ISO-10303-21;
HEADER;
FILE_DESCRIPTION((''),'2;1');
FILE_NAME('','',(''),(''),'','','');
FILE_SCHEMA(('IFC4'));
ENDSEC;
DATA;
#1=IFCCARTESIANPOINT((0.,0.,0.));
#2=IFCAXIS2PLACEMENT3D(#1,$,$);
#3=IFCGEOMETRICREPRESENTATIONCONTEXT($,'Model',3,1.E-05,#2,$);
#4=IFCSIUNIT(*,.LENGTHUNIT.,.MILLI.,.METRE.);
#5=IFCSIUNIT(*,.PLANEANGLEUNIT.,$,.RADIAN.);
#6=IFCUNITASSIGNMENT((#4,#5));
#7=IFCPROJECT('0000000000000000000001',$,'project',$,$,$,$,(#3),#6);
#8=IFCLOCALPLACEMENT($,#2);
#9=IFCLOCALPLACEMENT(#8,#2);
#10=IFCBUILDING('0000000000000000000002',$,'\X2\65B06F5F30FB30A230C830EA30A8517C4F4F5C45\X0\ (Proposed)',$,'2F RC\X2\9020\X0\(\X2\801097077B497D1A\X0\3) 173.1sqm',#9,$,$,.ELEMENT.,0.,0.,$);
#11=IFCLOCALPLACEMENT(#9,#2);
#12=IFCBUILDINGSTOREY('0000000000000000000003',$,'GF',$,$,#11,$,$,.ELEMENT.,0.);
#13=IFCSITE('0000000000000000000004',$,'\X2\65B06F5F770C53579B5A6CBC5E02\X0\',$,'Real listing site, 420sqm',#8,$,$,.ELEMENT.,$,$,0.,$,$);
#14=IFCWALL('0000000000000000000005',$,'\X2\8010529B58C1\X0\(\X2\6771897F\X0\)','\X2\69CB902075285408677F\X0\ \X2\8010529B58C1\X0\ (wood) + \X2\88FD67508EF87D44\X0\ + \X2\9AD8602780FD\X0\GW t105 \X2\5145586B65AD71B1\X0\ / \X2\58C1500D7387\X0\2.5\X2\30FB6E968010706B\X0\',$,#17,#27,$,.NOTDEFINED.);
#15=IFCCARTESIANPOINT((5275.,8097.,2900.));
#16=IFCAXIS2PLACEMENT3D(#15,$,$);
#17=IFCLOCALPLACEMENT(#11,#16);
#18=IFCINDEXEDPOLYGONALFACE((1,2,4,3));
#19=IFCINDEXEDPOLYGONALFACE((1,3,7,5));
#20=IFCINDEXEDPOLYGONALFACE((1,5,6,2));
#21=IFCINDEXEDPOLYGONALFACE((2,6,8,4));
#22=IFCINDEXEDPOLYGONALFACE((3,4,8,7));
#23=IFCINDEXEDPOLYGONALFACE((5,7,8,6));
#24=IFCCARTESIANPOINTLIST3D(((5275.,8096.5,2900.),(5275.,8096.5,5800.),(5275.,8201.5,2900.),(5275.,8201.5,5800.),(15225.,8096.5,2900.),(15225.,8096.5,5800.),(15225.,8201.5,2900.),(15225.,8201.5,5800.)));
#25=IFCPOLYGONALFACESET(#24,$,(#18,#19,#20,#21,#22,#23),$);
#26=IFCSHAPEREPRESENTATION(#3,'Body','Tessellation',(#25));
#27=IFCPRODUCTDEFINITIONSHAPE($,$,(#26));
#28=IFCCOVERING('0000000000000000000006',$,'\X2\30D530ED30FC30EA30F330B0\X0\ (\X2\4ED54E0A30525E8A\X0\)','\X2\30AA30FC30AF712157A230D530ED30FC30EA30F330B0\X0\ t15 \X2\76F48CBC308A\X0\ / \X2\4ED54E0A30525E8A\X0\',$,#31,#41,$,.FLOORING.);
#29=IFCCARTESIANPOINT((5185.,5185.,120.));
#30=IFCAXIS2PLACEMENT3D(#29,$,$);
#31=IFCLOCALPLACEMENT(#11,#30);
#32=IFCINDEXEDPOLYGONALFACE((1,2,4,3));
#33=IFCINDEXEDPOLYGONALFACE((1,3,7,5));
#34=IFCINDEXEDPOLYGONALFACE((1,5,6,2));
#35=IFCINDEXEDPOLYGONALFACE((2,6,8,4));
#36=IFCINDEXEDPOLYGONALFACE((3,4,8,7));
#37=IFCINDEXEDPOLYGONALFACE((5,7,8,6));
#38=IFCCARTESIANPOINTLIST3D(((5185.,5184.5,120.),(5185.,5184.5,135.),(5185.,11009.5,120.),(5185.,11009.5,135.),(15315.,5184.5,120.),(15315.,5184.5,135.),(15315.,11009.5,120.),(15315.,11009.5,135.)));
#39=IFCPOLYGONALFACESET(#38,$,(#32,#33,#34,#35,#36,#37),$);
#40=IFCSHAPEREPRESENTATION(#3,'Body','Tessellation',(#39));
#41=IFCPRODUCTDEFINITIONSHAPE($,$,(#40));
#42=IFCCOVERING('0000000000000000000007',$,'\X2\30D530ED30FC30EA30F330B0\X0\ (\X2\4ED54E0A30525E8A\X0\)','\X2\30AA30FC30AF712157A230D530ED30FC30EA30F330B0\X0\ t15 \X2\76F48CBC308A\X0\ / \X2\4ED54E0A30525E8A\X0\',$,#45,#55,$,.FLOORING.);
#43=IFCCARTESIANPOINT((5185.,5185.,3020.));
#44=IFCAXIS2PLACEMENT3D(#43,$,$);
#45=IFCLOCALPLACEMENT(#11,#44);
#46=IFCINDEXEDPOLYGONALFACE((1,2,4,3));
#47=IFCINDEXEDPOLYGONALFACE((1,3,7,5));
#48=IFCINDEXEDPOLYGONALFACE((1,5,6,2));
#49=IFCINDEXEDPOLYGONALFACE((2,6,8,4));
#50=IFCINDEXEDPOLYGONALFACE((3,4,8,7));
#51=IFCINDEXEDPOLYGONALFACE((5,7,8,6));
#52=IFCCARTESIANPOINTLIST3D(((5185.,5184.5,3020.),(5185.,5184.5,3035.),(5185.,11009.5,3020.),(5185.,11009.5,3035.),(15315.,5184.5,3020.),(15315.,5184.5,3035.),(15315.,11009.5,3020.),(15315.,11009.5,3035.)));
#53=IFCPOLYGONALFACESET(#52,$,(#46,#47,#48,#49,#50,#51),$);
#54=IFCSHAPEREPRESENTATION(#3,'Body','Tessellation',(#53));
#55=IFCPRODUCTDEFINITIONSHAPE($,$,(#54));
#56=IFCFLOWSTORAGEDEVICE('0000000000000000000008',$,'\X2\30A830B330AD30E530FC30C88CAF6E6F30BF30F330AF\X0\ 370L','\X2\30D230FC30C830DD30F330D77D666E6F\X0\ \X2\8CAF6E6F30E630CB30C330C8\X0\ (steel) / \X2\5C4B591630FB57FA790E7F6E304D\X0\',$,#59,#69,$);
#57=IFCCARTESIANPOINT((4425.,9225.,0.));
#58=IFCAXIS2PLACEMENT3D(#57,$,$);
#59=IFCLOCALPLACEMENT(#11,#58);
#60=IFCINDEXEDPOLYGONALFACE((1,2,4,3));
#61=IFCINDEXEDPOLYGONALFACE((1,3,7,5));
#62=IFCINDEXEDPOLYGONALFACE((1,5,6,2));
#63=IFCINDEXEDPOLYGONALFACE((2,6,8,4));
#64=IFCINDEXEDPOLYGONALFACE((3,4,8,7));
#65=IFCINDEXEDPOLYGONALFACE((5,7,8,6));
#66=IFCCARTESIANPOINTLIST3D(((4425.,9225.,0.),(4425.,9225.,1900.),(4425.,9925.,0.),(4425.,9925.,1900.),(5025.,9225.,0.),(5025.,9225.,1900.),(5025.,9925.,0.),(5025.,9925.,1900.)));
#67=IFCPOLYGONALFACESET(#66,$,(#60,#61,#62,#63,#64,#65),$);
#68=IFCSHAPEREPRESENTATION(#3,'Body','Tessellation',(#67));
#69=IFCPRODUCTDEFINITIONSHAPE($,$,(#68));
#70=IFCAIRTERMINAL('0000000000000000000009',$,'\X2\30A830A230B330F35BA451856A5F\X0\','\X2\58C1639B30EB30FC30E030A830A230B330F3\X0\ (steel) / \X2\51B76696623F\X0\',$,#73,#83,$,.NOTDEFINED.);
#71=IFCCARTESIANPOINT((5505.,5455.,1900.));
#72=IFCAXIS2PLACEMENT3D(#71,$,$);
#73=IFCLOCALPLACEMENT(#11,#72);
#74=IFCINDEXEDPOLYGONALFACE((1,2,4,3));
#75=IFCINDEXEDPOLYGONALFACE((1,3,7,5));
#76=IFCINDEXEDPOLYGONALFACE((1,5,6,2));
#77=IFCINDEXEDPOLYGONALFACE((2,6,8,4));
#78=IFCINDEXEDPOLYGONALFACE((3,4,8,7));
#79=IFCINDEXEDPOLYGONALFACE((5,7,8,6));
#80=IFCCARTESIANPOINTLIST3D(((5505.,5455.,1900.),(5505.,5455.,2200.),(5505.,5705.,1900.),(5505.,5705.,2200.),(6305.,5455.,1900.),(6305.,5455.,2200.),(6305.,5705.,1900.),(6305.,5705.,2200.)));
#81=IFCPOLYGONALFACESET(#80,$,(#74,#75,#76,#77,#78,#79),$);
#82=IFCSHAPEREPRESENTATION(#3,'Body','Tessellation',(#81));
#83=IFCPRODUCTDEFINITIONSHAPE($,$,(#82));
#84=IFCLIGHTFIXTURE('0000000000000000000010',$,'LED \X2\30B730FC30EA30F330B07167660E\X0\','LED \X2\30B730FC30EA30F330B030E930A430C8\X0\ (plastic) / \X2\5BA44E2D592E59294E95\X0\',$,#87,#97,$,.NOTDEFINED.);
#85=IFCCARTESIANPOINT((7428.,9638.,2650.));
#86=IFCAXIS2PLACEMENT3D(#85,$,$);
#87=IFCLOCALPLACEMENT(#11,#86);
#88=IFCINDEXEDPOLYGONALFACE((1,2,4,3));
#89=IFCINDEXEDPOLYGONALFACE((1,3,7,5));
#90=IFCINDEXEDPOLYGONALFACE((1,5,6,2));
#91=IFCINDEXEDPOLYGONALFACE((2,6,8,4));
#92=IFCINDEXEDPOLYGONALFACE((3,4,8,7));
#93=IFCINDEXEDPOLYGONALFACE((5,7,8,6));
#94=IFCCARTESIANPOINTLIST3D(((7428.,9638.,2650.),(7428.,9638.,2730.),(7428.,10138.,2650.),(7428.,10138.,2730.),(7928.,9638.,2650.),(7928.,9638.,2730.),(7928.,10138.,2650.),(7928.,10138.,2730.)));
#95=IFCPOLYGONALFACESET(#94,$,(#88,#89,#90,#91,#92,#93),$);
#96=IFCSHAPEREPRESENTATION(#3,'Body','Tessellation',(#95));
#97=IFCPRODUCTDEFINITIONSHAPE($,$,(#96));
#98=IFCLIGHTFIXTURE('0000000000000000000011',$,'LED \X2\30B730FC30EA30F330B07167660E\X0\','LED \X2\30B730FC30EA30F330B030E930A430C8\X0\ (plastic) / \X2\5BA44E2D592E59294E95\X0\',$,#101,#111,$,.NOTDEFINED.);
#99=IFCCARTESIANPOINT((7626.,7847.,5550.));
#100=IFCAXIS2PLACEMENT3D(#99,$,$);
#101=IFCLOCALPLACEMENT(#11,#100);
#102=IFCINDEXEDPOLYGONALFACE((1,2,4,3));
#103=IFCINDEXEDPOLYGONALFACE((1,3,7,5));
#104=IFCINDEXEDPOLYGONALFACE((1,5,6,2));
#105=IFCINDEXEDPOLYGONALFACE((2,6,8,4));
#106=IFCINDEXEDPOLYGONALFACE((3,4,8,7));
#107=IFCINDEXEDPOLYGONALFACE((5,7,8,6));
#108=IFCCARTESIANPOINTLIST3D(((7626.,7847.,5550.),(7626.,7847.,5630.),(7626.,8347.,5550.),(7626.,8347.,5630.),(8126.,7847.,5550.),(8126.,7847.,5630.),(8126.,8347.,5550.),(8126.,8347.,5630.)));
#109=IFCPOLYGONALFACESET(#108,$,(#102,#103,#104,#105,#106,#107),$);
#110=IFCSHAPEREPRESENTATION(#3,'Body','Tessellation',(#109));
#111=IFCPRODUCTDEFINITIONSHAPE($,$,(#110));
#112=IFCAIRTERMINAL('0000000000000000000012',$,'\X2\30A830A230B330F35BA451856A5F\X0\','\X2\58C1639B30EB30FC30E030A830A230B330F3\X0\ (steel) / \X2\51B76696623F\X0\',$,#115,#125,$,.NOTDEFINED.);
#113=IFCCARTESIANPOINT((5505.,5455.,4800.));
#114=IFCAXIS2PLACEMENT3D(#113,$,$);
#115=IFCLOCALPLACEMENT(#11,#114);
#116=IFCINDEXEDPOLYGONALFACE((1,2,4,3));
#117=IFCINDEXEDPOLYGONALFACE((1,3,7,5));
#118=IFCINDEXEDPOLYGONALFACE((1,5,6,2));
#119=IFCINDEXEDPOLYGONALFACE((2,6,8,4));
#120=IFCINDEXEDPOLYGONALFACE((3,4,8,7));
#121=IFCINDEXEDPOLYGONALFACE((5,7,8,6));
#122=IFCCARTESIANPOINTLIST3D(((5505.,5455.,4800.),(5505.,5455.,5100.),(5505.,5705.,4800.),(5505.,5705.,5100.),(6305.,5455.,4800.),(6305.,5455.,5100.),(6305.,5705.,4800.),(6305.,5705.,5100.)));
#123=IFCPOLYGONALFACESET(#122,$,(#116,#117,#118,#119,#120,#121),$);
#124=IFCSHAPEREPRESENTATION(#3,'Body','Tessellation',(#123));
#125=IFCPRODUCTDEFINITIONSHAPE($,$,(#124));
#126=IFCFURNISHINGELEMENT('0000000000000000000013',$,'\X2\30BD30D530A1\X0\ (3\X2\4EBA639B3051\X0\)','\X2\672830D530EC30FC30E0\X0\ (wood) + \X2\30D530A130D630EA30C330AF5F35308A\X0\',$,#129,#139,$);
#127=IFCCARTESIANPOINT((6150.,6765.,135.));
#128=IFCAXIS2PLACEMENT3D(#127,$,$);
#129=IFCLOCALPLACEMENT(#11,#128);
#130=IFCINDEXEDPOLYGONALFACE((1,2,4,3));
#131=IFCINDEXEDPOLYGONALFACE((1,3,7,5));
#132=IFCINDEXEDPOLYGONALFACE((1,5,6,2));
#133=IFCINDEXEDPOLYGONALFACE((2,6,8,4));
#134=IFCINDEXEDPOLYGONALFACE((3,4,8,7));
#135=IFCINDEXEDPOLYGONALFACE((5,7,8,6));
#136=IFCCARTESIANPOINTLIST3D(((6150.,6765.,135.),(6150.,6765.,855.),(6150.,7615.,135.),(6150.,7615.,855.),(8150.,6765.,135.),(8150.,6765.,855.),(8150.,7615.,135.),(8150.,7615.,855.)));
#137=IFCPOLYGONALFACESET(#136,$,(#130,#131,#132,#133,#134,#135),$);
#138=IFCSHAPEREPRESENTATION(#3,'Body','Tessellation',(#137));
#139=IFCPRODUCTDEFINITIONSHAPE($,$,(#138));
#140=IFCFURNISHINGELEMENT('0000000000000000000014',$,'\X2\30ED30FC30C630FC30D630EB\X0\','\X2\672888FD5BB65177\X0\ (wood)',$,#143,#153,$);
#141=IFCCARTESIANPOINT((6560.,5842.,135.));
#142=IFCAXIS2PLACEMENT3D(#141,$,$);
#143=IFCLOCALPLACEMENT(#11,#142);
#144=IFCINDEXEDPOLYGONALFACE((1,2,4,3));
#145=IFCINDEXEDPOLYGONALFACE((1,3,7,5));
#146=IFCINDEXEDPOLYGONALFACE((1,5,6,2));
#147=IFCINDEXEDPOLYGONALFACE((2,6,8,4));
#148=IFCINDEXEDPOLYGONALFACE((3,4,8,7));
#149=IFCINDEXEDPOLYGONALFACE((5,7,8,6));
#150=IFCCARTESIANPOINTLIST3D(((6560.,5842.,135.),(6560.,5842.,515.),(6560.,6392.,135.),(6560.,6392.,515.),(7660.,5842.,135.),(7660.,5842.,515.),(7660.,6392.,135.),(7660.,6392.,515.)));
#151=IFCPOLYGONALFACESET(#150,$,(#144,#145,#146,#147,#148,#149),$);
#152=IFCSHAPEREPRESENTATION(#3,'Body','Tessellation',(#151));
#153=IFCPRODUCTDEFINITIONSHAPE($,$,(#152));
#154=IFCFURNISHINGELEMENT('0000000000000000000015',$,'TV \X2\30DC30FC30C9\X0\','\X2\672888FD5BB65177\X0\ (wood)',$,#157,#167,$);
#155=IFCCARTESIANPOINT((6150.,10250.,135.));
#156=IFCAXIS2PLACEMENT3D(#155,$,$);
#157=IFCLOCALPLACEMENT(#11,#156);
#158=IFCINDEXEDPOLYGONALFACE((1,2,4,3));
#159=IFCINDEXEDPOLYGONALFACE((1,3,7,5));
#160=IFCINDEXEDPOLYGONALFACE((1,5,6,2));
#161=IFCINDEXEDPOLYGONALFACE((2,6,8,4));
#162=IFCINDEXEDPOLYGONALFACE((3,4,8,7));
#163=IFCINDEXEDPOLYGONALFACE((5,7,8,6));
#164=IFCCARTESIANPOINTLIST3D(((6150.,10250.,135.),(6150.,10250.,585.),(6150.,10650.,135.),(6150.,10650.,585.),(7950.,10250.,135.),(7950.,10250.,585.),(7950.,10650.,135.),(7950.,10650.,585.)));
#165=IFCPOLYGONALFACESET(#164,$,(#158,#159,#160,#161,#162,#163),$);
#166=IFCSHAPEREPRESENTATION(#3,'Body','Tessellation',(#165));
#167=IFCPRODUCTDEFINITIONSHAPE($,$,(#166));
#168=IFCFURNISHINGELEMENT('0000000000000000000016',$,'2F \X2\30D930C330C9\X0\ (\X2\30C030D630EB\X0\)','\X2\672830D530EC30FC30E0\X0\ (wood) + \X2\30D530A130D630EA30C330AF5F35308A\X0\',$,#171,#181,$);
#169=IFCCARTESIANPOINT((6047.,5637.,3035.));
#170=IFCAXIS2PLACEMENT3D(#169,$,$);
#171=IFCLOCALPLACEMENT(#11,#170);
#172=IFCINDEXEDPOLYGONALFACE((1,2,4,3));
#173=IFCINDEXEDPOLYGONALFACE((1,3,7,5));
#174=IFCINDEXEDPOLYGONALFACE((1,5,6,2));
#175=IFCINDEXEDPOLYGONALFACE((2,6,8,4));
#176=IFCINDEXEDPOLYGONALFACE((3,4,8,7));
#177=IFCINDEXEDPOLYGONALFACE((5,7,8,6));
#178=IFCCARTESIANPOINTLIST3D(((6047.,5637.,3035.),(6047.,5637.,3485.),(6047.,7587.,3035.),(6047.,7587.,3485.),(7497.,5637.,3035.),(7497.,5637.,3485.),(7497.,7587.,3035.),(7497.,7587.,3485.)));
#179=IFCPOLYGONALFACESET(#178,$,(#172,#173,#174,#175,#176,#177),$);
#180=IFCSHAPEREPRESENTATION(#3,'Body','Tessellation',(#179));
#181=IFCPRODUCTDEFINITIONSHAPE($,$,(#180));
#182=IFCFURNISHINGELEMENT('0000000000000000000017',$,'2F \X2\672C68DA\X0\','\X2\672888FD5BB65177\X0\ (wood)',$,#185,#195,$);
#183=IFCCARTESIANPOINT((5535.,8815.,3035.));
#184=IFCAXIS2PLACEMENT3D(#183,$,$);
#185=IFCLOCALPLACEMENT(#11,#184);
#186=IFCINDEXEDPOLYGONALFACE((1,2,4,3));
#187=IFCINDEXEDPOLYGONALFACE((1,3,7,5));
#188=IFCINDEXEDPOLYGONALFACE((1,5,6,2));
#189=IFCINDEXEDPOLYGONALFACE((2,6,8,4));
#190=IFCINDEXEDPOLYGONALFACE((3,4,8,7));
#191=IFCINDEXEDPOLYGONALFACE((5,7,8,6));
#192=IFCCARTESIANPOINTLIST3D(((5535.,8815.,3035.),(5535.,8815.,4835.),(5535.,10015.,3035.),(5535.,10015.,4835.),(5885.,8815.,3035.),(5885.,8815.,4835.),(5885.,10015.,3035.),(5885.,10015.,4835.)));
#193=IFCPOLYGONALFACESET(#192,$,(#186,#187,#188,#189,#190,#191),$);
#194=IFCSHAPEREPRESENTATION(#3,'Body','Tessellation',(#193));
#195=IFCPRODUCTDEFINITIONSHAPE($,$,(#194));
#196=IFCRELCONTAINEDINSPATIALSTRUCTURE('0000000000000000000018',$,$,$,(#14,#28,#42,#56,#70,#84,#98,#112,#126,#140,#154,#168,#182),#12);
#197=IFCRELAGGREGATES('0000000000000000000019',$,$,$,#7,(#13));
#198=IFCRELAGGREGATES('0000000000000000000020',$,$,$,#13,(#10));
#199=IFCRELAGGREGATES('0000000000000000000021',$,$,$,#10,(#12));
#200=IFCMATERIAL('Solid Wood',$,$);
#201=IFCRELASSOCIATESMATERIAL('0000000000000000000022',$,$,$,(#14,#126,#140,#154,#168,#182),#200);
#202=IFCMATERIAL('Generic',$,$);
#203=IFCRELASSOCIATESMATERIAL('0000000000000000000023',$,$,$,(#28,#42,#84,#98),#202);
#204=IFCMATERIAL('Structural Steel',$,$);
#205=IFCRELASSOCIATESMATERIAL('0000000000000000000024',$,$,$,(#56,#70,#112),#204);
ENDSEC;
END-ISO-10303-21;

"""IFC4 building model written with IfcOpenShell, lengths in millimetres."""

from ifc_helpers import new_model, si_unit, frame, frame_2d, origin, place, context, project, spatial, rectangle, extrude, material, element, save


model = new_model("IFC4")

# Units and contexts
model_context = context("Model", 3, precision=1e-05, world=origin())
ifc_project = project(units=[si_unit("LENGTHUNIT", "METRE", prefix="MILLI"), si_unit("PLANEANGLEUNIT", "RADIAN")], contexts=[model_context])

# Site, building, storey
site_placement = place(None, origin())
site = spatial("IfcSite", under=ifc_project, at=site_placement, Name="新潟県南魚沼市", ObjectType="Real listing site, 420sqm", CompositionType="ELEMENT", RefElevation=0.0)
building_placement = place(site_placement, origin())
building = spatial("IfcBuilding", under=site, at=building_placement, Name="新潟・アトリエ兼住居 (Proposed)", ObjectType="2F RC造(耐震等級3) 173.1sqm", CompositionType="ELEMENT", ElevationOfRefHeight=0.0, ElevationOfTerrain=0.0)
storey_placement = place(building_placement, origin())
storey = spatial("IfcBuildingStorey", under=building, at=storey_placement, Name="GF", CompositionType="ELEMENT", Elevation=0.0)

# Shared definitions
ifc_material_1 = material(Name="Solid Wood")

# Wall
wall_1_placement = place(storey_placement, frame((5275.0, 8097.0, 2900.0)))
element("IfcWall", 1, at=wall_1_placement, inside=storey, material=ifc_material_1, Name="耐力壁(東西)", Description="構造用合板 耐力壁 (wood) + 製材軸組 + 高性能GW t105 充填断熱 / 壁倍率2.5・準耐火", PredefinedType="NOTDEFINED", context=model_context, shape_type="SweptSolid", body=[
    extrude(rectangle(XDim=9950.0, YDim=105.0, at=frame_2d((4975.0, 52.0))), frame((5275.0, 8097.0, 2900.0)), (0.0, 0.0, 1.0), 2900.0),
])

# Coverings
ifc_material_2 = material(Name="Generic")
covering_1_placement = place(storey_placement, frame((5185.0, 5185.0, 120.0)))
element("IfcCovering", 2, at=covering_1_placement, inside=storey, material=ifc_material_2, Name="フローリング (仕上げ床)", Description="オーク無垢フローリング t15 直貼り / 仕上げ床", PredefinedType="FLOORING", context=model_context, shape_type="SweptSolid", body=[
    extrude(rectangle(XDim=10130.0, YDim=5825.0, at=frame_2d((5065.0, 2912.0))), frame((5185.0, 5185.0, 120.0)), (0.0, 0.0, 1.0), 15.0),
])
covering_2_placement = place(storey_placement, frame((5185.0, 5185.0, 3020.0)))
element("IfcCovering", 3, at=covering_2_placement, inside=storey, material=ifc_material_2, Name="フローリング (仕上げ床)", Description="オーク無垢フローリング t15 直貼り / 仕上げ床", PredefinedType="FLOORING", context=model_context, shape_type="SweptSolid", body=[
    extrude(rectangle(XDim=10130.0, YDim=5825.0, at=frame_2d((5065.0, 2912.0))), frame((5185.0, 5185.0, 3020.0)), (0.0, 0.0, 1.0), 15.0),
])

# Flow storage device
ifc_material_3 = material(Name="Structural Steel")
flow_storage_device_placement = place(storey_placement, frame((4425.0, 9225.0, 0.0)))
element("IfcFlowStorageDevice", 4, at=flow_storage_device_placement, inside=storey, material=ifc_material_3, Name="エコキュート貯湯タンク 370L", Description="ヒートポンプ給湯 貯湯ユニット (steel) / 屋外・基礎置き", context=model_context, shape_type="SweptSolid", body=[
    extrude(rectangle(XDim=600.0, YDim=700.0, at=frame_2d((300.0, 350.0))), frame((4425.0, 9225.0, 0.0)), (0.0, 0.0, 1.0), 1900.0),
])

# Air terminal
air_terminal_1_placement = place(storey_placement, frame((5505.0, 5455.0, 1900.0)))
element("IfcAirTerminal", 5, at=air_terminal_1_placement, inside=storey, material=ifc_material_3, Name="エアコン室内機", Description="壁掛ルームエアコン (steel) / 冷暖房", PredefinedType="NOTDEFINED", context=model_context, shape_type="SweptSolid", body=[
    extrude(rectangle(XDim=800.0, YDim=250.0, at=frame_2d((400.0, 125.0))), frame((5505.0, 5455.0, 1900.0)), (0.0, 0.0, 1.0), 300.0),
])

# Light fixtures
light_fixture_1_placement = place(storey_placement, frame((7428.0, 9638.0, 2650.0)))
element("IfcLightFixture", 6, at=light_fixture_1_placement, inside=storey, material=ifc_material_2, Name="LED シーリング照明", Description="LED シーリングライト (plastic) / 室中央天井", PredefinedType="NOTDEFINED", context=model_context, shape_type="SweptSolid", body=[
    extrude(rectangle(XDim=500.0, YDim=500.0, at=frame_2d((250.0, 250.0))), frame((7428.0, 9638.0, 2650.0)), (0.0, 0.0, 1.0), 80.0),
])
light_fixture_2_placement = place(storey_placement, frame((7626.0, 7847.0, 5550.0)))
element("IfcLightFixture", 7, at=light_fixture_2_placement, inside=storey, material=ifc_material_2, Name="LED シーリング照明", Description="LED シーリングライト (plastic) / 室中央天井", PredefinedType="NOTDEFINED", context=model_context, shape_type="SweptSolid", body=[
    extrude(rectangle(XDim=500.0, YDim=500.0, at=frame_2d((250.0, 250.0))), frame((7626.0, 7847.0, 5550.0)), (0.0, 0.0, 1.0), 80.0),
])

# Air terminal
air_terminal_2_placement = place(storey_placement, frame((5505.0, 5455.0, 4800.0)))
element("IfcAirTerminal", 8, at=air_terminal_2_placement, inside=storey, material=ifc_material_3, Name="エアコン室内機", Description="壁掛ルームエアコン (steel) / 冷暖房", PredefinedType="NOTDEFINED", context=model_context, shape_type="SweptSolid", body=[
    extrude(rectangle(XDim=800.0, YDim=250.0, at=frame_2d((400.0, 125.0))), frame((5505.0, 5455.0, 4800.0)), (0.0, 0.0, 1.0), 300.0),
])

# Furnishing elements
furnishing_1_placement = place(storey_placement, frame((6150.0, 6765.0, 135.0)))
element("IfcFurnishingElement", 9, at=furnishing_1_placement, inside=storey, material=ifc_material_1, Name="ソファ (3人掛け)", Description="木フレーム (wood) + ファブリック張り", context=model_context, shape_type="SweptSolid", body=[
    extrude(rectangle(XDim=2000.0, YDim=850.0, at=frame_2d((1000.0, 425.0))), frame((6150.0, 6765.0, 135.0)), (0.0, 0.0, 1.0), 720.0),
])
furnishing_2_placement = place(storey_placement, frame((6560.0, 5842.0, 135.0)))
element("IfcFurnishingElement", 10, at=furnishing_2_placement, inside=storey, material=ifc_material_1, Name="ローテーブル", Description="木製家具 (wood)", context=model_context, shape_type="SweptSolid", body=[
    extrude(rectangle(XDim=1100.0, YDim=550.0, at=frame_2d((550.0, 275.0))), frame((6560.0, 5842.0, 135.0)), (0.0, 0.0, 1.0), 380.0),
])
furnishing_3_placement = place(storey_placement, frame((6150.0, 10250.0, 135.0)))
element("IfcFurnishingElement", 11, at=furnishing_3_placement, inside=storey, material=ifc_material_1, Name="TV ボード", Description="木製家具 (wood)", context=model_context, shape_type="SweptSolid", body=[
    extrude(rectangle(XDim=1800.0, YDim=400.0, at=frame_2d((900.0, 200.0))), frame((6150.0, 10250.0, 135.0)), (0.0, 0.0, 1.0), 450.0),
])
furnishing_4_placement = place(storey_placement, frame((6047.0, 5637.0, 3035.0)))
element("IfcFurnishingElement", 12, at=furnishing_4_placement, inside=storey, material=ifc_material_1, Name="2F ベッド (ダブル)", Description="木フレーム (wood) + ファブリック張り", context=model_context, shape_type="SweptSolid", body=[
    extrude(rectangle(XDim=1450.0, YDim=1950.0, at=frame_2d((725.0, 975.0))), frame((6047.0, 5637.0, 3035.0)), (0.0, 0.0, 1.0), 450.0),
])
furnishing_5_placement = place(storey_placement, frame((5535.0, 8815.0, 3035.0)))
element("IfcFurnishingElement", 13, at=furnishing_5_placement, inside=storey, material=ifc_material_1, Name="2F 本棚", Description="木製家具 (wood)", context=model_context, shape_type="SweptSolid", body=[
    extrude(rectangle(XDim=350.0, YDim=1200.0, at=frame_2d((175.0, 600.0))), frame((5535.0, 8815.0, 3035.0)), (0.0, 0.0, 1.0), 1800.0),
])

save(model, "model.ifc")
